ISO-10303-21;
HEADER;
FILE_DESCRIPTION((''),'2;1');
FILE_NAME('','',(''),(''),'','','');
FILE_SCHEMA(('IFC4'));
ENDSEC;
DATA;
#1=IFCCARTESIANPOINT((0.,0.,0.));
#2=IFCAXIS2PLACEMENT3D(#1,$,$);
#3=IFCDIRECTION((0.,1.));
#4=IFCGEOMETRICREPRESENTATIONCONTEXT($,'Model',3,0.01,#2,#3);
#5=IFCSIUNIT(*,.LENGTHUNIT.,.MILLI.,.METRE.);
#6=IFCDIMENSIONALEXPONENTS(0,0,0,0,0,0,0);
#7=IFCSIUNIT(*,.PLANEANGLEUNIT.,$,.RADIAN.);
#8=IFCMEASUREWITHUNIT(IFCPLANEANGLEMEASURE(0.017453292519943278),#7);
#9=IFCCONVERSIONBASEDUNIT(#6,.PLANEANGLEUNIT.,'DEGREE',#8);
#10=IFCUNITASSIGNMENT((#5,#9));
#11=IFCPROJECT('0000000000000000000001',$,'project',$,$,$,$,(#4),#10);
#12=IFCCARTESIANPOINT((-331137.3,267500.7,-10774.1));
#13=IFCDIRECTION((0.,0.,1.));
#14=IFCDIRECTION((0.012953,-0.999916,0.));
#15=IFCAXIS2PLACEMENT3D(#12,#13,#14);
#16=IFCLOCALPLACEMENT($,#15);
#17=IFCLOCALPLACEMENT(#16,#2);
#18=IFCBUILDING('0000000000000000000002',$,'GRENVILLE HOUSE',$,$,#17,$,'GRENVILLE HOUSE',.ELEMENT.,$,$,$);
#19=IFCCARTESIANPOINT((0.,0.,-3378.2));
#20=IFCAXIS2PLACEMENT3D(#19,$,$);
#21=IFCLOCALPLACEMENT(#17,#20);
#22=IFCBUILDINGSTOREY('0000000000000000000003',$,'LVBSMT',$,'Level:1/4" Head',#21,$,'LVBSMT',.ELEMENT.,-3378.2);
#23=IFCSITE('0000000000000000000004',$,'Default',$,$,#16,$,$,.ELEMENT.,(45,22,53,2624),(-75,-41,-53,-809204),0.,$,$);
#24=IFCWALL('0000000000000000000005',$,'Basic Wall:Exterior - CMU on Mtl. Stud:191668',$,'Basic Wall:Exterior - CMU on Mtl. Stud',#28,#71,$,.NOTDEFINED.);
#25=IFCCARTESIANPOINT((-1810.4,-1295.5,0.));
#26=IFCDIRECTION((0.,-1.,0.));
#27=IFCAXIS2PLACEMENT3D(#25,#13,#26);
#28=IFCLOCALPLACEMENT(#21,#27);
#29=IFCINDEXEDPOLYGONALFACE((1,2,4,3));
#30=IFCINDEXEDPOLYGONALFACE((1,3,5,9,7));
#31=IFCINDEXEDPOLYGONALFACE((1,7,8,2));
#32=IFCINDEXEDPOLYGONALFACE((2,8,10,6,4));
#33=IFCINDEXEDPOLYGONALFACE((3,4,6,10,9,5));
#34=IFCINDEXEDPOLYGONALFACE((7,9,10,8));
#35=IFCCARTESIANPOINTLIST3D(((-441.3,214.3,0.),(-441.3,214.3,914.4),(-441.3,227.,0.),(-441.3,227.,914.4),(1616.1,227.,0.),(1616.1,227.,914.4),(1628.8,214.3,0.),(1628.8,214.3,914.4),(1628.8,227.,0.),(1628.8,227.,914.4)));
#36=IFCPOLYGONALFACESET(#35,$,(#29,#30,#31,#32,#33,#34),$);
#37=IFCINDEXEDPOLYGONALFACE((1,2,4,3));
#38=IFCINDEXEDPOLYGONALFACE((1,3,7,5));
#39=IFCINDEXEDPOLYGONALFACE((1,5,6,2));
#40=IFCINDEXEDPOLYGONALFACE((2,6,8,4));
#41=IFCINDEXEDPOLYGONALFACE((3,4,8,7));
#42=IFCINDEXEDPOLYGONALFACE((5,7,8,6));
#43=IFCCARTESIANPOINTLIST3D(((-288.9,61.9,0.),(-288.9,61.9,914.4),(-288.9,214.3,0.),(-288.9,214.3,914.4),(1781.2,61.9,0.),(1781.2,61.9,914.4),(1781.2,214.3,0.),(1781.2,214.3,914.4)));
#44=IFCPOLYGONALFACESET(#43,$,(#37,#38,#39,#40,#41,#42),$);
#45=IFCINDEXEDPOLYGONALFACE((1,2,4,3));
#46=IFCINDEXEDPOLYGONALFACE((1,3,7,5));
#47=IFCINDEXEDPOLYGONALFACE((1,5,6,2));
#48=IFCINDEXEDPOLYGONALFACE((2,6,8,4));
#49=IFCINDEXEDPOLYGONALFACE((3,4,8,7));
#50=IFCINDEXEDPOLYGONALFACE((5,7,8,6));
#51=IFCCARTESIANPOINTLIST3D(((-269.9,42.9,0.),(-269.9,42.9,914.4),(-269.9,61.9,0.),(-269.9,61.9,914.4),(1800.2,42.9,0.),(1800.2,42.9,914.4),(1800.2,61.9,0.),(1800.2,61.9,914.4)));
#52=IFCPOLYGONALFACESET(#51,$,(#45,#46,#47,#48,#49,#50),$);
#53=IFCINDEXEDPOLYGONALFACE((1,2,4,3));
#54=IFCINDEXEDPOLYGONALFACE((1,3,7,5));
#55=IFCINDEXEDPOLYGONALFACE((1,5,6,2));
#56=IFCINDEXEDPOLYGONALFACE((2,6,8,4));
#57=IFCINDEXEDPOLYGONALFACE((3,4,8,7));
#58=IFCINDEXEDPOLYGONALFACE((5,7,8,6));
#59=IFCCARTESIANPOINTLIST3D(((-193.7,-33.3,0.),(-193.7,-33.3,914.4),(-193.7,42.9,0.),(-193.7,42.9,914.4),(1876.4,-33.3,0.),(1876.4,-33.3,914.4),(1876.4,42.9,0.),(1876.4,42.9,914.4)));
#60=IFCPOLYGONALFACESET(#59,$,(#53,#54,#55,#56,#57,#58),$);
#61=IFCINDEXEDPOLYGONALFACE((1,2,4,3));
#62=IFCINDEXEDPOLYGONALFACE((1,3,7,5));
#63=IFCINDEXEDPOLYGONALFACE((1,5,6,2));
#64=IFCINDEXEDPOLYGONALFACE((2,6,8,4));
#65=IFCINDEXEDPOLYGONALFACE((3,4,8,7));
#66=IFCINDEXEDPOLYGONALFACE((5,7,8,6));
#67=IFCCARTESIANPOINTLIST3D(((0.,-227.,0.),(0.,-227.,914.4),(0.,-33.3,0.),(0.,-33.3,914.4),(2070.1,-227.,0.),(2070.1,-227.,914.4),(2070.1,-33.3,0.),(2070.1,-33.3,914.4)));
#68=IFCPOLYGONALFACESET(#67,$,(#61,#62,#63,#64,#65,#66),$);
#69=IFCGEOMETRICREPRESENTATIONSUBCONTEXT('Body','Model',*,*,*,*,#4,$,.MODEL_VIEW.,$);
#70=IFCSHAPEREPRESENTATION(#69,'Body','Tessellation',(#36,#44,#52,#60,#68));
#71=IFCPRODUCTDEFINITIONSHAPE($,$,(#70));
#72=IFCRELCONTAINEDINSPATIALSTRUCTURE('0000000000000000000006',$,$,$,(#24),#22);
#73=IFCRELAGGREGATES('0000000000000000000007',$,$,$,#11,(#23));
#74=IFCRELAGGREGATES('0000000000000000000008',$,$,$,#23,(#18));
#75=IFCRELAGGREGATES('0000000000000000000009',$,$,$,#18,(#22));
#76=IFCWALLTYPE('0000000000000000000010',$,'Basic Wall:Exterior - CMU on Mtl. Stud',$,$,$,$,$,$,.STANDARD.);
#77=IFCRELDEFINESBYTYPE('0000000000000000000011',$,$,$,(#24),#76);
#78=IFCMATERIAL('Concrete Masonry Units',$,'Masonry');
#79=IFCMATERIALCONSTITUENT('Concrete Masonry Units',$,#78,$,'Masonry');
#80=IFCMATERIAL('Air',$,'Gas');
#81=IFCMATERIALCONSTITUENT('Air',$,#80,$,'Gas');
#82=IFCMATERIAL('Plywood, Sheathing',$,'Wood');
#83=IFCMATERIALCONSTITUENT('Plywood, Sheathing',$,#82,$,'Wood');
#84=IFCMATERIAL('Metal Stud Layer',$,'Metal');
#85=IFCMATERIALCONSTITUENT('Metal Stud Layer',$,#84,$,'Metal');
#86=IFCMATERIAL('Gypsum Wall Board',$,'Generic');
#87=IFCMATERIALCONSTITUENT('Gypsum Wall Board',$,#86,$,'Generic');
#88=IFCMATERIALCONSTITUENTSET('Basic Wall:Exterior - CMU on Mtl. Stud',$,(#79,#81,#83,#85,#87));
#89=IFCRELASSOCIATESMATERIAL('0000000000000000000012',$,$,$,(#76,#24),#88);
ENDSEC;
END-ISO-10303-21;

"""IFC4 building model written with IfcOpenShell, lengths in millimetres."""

from ifc_helpers import new_model, entity, si_unit, converted_unit, direction, frame, origin, place, context, subcontext, project, spatial, indexed_curve, outline, extrude, material, constituent, constituent_set, type_object, element, save


model = new_model("IFC4")

# Units and contexts
model_context = context("Model", 3, precision=0.01, world=origin(), true_north=direction((0.0, 1.0)))
body_context = subcontext(model_context, "Body", "Model", "MODEL_VIEW")
ifc_project = project(units=[si_unit("LENGTHUNIT", "METRE", prefix="MILLI"), converted_unit("PLANEANGLEUNIT", "DEGREE", entity("IfcPlaneAngleMeasure", 0.017453292519943278), si_unit("PLANEANGLEUNIT", "RADIAN"), dimensions=[0, 0, 0, 0, 0, 0, 0])], contexts=[model_context])

# Site, building, storey
site_placement = place(None, frame((-331137.3, 267500.7, -10774.1), z_axis=(0.0, 0.0, 1.0), x_axis=(0.012953, -0.999916, 0.0)))
site = spatial("IfcSite", under=ifc_project, at=site_placement, Name="Default", CompositionType="ELEMENT", RefLatitude=(45, 22, 53, 2624), RefLongitude=(-75, -41, -53, -809204), RefElevation=0.0)
building_placement = place(site_placement, origin())
building = spatial("IfcBuilding", under=site, at=building_placement, Name="GRENVILLE HOUSE", LongName="GRENVILLE HOUSE", CompositionType="ELEMENT")
storey_placement = place(building_placement, frame((0.0, 0.0, -3378.2)))
storey = spatial("IfcBuildingStorey", under=building, at=storey_placement, Name="LVBSMT", ObjectType="Level:1/4\" Head", LongName="LVBSMT", CompositionType="ELEMENT", Elevation=-3378.2)

# Shared definitions
ifc_material_1 = material(Name="Concrete Masonry Units", Category="Masonry")

# Wall
ifc_constituent_1 = constituent(ifc_material_1, Name="Concrete Masonry Units", Category="Masonry")
ifc_material_2 = material(Name="Air", Category="Gas")
ifc_constituent_2 = constituent(ifc_material_2, Name="Air", Category="Gas")
ifc_material_3 = material(Name="Plywood, Sheathing", Category="Wood")
ifc_constituent_3 = constituent(ifc_material_3, Name="Plywood, Sheathing", Category="Wood")
ifc_material_4 = material(Name="Metal Stud Layer", Category="Metal")
ifc_constituent_4 = constituent(ifc_material_4, Name="Metal Stud Layer", Category="Metal")
ifc_material_5 = material(Name="Gypsum Wall Board", Category="Generic")
ifc_constituent_5 = constituent(ifc_material_5, Name="Gypsum Wall Board", Category="Generic")
ifc_constituent_set = constituent_set(constituents=[ifc_constituent_1, ifc_constituent_2, ifc_constituent_3, ifc_constituent_4, ifc_constituent_5], Name="Basic Wall:Exterior - CMU on Mtl. Stud")
wall_type_1 = type_object("IfcWallType", Name="Basic Wall:Exterior - CMU on Mtl. Stud", PredefinedType="STANDARD", material=ifc_constituent_set)
wall_1_placement = place(storey_placement, frame((-1810.4, -1295.5, 0.0), z_axis=(0.0, 0.0, 1.0), x_axis=(0.0, -1.0, 0.0)))
element("IfcWall", 1, at=wall_1_placement, inside=storey, type_object=wall_type_1, material=ifc_constituent_set, Name="Basic Wall:Exterior - CMU on Mtl. Stud:191668", ObjectType="Basic Wall:Exterior - CMU on Mtl. Stud", PredefinedType="NOTDEFINED", context=body_context, shape_type="SweptSolid", body=[
    extrude(outline(indexed_curve([(-817.9, -5.1), (1239.5, -5.1), (1239.5, 7.6), (-830.6, 7.6), (-830.6, -5.1), (-817.9, -5.1)], self_intersect=False)), frame((798.2, 221.9, 0.0), z_axis=(0.0, 0.0, 1.0), x_axis=(-1.0, 0.0, 0.0)), (0.0, 0.0, 1.0), 914.4),
    extrude(outline(indexed_curve([(-1035.1, -76.2), (1035.1, -76.2), (1035.1, 76.2), (-1035.1, 76.2), (-1035.1, -76.2)], self_intersect=False)), frame((746.1, 138.1, 0.0)), (0.0, 0.0, 1.0), 914.4),
    extrude(outline(indexed_curve([(-1035.1, -9.5), (1035.1, -9.5), (1035.1, 9.5), (-1035.1, 9.5), (-1035.1, -9.5)], self_intersect=False)), frame((765.2, 52.4, 0.0)), (0.0, 0.0, 1.0), 914.4),
    extrude(outline(indexed_curve([(-1035.1, -38.1), (1035.1, -38.1), (1035.1, 38.1), (-1035.1, 38.1), (-1035.1, -38.1)], self_intersect=False)), frame((841.4, 4.8, 0.0)), (0.0, 0.0, 1.0), 914.4),
    extrude(outline(indexed_curve([(-96.8, -1035.1), (96.8, -1035.1), (96.8, 1035.1), (-96.8, 1035.1), (-96.8, -1035.1)], self_intersect=False)), frame((1035.1, -130.2, 0.0), z_axis=(0.0, 0.0, 1.0), x_axis=(0.0, 1.0, 0.0)), (0.0, 0.0, 1.0), 914.4),
])

save(model, "model.ifc")
